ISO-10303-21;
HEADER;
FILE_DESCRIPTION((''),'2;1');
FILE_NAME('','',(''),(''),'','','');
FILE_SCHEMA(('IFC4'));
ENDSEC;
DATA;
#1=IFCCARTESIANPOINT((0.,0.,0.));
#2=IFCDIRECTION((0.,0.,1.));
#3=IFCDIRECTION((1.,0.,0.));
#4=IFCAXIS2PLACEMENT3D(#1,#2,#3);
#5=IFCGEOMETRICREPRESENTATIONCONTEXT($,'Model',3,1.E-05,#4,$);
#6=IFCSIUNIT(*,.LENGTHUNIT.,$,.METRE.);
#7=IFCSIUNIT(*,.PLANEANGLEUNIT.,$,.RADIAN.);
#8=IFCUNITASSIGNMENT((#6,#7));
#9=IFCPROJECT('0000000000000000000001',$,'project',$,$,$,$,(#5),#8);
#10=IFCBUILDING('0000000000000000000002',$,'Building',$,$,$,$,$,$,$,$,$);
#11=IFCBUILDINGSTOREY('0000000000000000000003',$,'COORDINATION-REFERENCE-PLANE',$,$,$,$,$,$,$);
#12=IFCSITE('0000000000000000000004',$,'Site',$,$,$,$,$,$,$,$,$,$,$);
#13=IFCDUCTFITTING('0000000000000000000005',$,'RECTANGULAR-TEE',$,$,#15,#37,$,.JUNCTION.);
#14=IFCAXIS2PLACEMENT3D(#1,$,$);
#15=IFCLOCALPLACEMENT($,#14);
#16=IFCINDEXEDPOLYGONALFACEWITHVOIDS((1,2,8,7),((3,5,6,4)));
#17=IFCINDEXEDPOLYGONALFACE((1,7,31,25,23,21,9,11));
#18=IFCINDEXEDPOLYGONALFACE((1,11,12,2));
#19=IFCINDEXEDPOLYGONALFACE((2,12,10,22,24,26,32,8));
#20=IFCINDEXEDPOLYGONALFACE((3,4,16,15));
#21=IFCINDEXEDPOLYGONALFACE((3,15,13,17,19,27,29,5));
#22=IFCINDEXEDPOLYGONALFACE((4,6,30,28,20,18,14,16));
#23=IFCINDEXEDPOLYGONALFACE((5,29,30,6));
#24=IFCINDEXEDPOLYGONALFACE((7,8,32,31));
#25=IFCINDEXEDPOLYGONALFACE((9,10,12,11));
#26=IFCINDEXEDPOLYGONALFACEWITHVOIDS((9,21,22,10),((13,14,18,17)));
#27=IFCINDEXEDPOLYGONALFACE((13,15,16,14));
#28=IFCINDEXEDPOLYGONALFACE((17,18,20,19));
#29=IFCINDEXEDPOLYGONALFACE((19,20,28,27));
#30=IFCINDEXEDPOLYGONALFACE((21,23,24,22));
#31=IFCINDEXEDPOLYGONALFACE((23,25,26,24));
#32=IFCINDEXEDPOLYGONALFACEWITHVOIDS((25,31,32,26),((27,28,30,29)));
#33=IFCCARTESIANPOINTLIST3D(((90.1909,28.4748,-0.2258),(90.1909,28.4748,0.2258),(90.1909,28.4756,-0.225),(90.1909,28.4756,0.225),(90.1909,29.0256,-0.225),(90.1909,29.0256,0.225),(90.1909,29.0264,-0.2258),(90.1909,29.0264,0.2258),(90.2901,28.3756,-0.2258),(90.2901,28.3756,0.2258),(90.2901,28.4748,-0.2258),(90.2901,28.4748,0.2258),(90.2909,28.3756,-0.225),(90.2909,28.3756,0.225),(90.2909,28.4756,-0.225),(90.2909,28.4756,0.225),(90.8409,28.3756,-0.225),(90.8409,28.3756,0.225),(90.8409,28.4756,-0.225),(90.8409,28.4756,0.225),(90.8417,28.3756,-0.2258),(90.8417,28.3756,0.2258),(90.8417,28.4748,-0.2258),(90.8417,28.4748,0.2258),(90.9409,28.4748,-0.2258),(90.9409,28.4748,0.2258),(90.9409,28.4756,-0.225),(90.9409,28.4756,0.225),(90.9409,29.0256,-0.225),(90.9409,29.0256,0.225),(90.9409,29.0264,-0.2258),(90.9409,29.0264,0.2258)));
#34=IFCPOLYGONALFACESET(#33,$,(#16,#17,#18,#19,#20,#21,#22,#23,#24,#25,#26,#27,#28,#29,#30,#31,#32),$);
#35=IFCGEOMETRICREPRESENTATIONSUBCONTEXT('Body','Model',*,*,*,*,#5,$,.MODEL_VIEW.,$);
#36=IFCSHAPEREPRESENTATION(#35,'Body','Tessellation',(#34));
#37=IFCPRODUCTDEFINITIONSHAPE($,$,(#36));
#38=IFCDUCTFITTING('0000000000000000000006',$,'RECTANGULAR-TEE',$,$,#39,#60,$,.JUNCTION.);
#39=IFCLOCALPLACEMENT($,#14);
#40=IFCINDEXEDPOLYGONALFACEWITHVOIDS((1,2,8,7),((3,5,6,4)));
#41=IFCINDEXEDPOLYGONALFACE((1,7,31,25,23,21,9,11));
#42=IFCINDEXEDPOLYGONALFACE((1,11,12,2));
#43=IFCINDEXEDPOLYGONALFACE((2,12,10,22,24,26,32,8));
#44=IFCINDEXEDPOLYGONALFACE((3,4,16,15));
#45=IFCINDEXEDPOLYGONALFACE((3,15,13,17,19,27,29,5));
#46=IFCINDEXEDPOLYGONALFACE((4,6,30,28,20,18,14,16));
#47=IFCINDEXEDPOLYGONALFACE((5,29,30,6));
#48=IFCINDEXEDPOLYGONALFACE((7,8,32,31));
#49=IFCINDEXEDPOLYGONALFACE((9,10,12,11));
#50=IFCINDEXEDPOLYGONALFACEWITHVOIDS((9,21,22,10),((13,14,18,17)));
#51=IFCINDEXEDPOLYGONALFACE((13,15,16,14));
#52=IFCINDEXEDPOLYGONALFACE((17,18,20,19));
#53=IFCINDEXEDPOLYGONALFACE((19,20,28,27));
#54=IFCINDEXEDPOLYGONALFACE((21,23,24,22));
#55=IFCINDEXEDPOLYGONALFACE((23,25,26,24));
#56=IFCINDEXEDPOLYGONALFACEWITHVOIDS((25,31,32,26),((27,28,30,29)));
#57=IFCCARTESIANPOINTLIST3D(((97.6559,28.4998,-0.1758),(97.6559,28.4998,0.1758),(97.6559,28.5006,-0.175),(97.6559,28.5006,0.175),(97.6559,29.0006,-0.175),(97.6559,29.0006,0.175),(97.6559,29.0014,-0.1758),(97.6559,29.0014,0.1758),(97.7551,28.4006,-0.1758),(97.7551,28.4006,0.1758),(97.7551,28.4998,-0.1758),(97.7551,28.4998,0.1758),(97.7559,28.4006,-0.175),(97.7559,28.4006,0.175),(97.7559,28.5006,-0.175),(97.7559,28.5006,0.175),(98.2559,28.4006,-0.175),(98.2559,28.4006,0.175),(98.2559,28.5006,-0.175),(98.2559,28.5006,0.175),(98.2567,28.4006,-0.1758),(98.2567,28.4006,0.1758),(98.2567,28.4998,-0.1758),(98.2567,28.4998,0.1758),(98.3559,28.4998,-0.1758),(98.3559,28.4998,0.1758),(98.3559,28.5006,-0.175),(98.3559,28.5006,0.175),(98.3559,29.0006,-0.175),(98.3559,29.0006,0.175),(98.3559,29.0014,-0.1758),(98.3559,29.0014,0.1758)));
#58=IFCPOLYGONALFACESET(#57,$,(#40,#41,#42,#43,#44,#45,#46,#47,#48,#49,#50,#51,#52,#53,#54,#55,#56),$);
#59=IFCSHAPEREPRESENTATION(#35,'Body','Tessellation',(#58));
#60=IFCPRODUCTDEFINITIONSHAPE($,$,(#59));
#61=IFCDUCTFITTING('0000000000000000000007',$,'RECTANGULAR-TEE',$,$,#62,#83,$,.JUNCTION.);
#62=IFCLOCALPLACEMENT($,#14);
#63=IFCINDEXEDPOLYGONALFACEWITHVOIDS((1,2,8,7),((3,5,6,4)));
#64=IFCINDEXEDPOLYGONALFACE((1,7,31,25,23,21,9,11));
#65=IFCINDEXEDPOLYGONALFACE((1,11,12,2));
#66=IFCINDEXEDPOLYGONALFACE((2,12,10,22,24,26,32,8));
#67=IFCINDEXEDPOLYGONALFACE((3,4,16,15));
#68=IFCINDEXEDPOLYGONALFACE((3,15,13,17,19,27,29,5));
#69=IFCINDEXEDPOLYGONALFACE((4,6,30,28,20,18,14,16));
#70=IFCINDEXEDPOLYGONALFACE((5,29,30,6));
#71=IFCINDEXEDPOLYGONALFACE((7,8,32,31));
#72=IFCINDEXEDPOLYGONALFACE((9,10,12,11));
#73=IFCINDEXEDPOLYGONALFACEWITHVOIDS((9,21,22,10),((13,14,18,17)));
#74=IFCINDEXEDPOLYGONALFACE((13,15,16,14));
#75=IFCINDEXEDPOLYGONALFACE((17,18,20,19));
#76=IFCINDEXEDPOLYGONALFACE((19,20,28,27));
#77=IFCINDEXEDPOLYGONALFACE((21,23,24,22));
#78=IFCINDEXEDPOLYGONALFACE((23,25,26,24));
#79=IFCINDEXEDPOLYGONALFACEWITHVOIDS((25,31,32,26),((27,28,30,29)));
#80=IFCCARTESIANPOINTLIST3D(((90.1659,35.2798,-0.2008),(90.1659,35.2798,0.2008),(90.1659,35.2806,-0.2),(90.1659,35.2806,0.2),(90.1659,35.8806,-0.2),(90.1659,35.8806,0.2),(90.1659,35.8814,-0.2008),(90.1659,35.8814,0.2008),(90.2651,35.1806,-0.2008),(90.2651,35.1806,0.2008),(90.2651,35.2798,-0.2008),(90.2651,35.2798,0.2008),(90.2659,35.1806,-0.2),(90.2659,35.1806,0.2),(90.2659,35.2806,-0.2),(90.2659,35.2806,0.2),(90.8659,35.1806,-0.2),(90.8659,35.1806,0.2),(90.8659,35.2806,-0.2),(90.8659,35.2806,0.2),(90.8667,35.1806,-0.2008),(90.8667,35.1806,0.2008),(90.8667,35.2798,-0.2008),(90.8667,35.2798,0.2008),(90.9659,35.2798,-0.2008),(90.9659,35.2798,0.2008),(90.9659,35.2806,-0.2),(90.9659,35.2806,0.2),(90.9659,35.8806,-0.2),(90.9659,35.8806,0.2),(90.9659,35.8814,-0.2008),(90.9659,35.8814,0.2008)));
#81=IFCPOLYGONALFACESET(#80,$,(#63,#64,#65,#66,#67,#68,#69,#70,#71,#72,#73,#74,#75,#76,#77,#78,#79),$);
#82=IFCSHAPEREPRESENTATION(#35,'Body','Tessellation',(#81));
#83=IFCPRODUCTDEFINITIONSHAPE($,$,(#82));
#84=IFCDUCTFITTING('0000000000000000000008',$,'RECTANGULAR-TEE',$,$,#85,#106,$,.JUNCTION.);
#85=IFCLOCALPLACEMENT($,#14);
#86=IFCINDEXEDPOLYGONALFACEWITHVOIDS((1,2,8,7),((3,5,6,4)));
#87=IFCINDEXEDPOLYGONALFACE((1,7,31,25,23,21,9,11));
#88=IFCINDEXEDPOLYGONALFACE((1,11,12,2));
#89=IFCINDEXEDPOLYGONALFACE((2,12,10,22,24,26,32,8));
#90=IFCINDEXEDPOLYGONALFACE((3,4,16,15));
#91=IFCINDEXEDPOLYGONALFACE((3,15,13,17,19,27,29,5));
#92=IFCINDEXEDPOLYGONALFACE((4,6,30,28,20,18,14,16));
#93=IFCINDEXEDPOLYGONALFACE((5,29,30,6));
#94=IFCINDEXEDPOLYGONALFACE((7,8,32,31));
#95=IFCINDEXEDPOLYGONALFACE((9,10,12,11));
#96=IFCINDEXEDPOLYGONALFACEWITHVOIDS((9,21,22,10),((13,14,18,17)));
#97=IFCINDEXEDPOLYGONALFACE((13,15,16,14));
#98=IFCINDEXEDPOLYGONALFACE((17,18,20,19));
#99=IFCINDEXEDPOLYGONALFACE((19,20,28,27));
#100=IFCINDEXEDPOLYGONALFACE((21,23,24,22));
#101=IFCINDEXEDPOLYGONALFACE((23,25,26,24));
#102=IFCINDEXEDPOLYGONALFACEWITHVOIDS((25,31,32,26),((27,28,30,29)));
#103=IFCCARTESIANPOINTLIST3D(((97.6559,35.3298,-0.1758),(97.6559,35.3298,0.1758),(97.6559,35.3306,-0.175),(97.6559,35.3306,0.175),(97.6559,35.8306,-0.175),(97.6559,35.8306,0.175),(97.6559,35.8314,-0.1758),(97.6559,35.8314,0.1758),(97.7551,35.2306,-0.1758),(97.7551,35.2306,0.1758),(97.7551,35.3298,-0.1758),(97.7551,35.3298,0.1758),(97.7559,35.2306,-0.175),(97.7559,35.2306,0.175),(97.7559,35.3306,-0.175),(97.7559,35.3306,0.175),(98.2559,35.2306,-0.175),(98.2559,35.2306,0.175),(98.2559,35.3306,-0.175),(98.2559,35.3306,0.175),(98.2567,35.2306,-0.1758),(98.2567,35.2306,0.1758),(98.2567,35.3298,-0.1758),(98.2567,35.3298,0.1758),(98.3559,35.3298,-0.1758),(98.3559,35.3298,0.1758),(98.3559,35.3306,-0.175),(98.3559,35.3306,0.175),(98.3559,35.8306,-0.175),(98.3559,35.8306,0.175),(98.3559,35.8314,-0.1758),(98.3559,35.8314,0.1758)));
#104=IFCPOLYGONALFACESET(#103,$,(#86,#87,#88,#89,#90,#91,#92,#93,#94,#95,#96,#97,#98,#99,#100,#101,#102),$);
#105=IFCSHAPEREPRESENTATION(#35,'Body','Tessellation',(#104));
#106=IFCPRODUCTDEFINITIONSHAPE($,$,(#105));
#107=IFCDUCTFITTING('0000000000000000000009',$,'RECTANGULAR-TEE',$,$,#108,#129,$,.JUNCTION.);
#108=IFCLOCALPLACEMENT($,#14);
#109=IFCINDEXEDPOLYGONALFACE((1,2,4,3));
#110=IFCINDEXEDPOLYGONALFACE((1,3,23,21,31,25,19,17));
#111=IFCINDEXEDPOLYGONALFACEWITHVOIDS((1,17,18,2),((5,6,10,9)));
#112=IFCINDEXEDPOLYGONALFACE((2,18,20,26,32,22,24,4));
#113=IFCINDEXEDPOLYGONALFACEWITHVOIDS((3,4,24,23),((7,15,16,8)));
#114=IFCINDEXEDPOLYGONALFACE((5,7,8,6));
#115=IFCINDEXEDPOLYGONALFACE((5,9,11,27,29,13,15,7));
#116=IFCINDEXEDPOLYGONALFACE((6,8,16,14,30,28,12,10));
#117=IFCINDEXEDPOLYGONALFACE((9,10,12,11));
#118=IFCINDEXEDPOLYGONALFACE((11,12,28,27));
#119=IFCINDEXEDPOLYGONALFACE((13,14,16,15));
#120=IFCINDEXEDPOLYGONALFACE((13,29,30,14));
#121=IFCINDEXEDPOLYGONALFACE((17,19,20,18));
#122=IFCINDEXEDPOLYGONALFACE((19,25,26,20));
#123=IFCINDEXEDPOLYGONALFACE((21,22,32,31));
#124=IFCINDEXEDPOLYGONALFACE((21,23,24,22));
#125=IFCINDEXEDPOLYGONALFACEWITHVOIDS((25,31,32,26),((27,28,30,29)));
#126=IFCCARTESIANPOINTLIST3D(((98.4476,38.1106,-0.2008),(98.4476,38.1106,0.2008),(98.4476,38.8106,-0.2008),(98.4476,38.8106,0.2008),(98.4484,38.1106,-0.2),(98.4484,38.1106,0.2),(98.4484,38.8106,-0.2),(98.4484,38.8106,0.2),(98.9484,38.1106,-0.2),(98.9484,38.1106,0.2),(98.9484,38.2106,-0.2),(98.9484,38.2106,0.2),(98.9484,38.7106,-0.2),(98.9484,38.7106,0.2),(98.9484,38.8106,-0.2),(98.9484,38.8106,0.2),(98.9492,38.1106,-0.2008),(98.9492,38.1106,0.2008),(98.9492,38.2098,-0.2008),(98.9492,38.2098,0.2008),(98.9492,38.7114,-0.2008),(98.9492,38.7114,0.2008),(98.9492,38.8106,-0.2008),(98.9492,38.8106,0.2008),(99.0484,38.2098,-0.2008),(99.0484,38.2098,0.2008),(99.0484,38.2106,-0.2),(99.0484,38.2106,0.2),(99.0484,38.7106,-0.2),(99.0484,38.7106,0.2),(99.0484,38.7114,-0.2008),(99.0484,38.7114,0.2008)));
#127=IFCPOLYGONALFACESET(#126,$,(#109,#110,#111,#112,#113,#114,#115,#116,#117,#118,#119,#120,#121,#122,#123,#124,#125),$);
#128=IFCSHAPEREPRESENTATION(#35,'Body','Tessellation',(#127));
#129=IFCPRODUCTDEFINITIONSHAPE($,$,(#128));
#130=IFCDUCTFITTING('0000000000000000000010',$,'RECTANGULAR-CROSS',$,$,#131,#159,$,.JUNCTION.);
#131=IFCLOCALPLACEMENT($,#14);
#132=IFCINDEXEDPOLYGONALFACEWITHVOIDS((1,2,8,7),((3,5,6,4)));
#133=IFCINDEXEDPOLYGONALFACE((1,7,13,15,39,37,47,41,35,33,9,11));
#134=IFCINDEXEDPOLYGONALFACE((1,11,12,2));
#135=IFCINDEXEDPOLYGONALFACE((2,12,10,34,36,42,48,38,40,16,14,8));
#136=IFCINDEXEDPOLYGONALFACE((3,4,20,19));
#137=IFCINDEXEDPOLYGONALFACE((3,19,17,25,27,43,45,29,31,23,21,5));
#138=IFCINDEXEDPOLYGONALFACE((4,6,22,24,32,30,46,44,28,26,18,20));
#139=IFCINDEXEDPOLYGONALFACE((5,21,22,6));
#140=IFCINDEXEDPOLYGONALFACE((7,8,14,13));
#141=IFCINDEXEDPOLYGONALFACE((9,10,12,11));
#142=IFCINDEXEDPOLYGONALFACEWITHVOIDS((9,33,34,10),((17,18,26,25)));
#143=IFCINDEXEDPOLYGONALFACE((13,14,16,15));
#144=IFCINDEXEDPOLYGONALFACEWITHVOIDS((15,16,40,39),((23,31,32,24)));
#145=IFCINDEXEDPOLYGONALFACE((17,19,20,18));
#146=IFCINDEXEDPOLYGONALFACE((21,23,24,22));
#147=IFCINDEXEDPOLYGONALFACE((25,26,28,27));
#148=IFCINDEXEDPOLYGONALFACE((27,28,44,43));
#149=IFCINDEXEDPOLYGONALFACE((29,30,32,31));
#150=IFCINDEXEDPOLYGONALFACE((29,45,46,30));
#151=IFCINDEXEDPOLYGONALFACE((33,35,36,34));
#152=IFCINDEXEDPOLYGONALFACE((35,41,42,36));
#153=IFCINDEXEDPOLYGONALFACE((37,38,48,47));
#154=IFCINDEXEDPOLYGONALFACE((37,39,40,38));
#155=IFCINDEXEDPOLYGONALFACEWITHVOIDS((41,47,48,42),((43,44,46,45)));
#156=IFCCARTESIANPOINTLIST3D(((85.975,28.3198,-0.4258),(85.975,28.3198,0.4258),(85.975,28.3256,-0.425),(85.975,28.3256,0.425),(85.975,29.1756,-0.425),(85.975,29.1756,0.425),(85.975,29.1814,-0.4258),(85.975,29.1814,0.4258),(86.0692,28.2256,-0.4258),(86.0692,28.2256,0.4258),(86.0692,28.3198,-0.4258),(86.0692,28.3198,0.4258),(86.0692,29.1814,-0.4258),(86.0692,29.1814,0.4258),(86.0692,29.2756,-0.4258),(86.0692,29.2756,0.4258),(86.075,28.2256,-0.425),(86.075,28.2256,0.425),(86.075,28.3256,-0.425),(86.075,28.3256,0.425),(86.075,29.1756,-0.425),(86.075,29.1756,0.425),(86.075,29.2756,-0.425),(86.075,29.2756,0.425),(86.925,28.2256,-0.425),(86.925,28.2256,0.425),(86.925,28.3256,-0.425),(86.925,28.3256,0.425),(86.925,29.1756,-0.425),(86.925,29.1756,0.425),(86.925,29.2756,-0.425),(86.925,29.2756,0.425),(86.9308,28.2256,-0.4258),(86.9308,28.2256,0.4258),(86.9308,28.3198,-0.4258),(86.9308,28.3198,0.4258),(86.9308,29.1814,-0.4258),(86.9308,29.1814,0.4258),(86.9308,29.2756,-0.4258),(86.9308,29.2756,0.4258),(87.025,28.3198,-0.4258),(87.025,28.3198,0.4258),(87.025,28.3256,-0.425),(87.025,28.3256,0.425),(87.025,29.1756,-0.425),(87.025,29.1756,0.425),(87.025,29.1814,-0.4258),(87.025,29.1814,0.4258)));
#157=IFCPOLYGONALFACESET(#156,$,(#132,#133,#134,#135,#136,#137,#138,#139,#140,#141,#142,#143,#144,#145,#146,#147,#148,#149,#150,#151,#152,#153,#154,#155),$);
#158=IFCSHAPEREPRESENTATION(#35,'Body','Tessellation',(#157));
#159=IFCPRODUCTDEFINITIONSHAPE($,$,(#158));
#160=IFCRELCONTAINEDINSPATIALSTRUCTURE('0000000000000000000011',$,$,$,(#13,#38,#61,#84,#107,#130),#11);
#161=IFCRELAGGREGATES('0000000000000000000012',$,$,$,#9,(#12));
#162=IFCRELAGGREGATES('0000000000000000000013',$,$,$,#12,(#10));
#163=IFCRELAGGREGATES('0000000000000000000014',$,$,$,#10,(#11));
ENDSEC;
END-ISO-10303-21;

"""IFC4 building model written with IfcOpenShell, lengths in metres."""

from ifc_helpers import new_model, si_unit, frame, origin_with_axes, place, context, subcontext, project, spatial, rectangle, extrude, boolean, element, save


model = new_model("IFC4")

# Units and contexts
model_context = context("Model", 3, precision=1e-05, world=origin_with_axes())
body_context = subcontext(model_context, "Body", "Model", "MODEL_VIEW")
ifc_project = project(units=[si_unit("LENGTHUNIT", "METRE"), si_unit("PLANEANGLEUNIT", "RADIAN")], contexts=[model_context])

# Site, building, storey
site = spatial("IfcSite", under=ifc_project, Name="Site")
building = spatial("IfcBuilding", under=site, Name="Building")
storey = spatial("IfcBuildingStorey", under=building, Name="COORDINATION-REFERENCE-PLANE")

# Duct fittings
duct_fitting_1_placement = place(None, frame((90.5659, 28.7506, 0.0), z_axis=(1.0, 0.0, 0.0), x_axis=(0.0, -1.0, 0.0)))
solid_1 = boolean("UNION", extrude(rectangle(XDim=0.55, YDim=0.45), frame((0.0, 0.0, -0.375), z_axis=(0.0, 0.0, 1.0), x_axis=(1.0, 0.0, 0.0)), (0.0, 0.0, 1.0), 0.75), extrude(rectangle(XDim=0.55, YDim=0.45), frame((0.0, 0.0, 0.0), z_axis=(1.0, 0.0, 0.0), x_axis=(0.0, 0.0, -1.0)), (0.0, 0.0, 1.0), 0.375))
element("IfcDuctFitting", 1, at=duct_fitting_1_placement, inside=storey, Name="RECTANGULAR-TEE", PredefinedType="JUNCTION", context=body_context, shape_type="CSG", body=[
    boolean("DIFFERENCE", boolean("UNION", extrude(rectangle(XDim=0.5516, YDim=0.4516), frame((0.0, 0.0, -0.375), z_axis=(0.0, 0.0, 1.0), x_axis=(1.0, 0.0, 0.0)), (0.0, 0.0, 1.0), 0.75), extrude(rectangle(XDim=0.5516, YDim=0.4516), frame((0.0, 0.0, 0.0), z_axis=(1.0, 0.0, 0.0), x_axis=(0.0, 0.0, -1.0)), (0.0, 0.0, 1.0), 0.375)), solid_1),
])
duct_fitting_2_placement = place(None, frame((98.0059, 28.7506, 0.0), z_axis=(1.0, 0.0, 0.0), x_axis=(0.0, -1.0, 0.0)))
solid_2 = boolean("UNION", extrude(rectangle(XDim=0.5, YDim=0.35), frame((0.0, 0.0, -0.35), z_axis=(0.0, 0.0, 1.0), x_axis=(1.0, 0.0, 0.0)), (0.0, 0.0, 1.0), 0.7), extrude(rectangle(XDim=0.5, YDim=0.35), frame((0.0, 0.0, 0.0), z_axis=(1.0, 0.0, 0.0), x_axis=(0.0, 0.0, -1.0)), (0.0, 0.0, 1.0), 0.35))
element("IfcDuctFitting", 2, at=duct_fitting_2_placement, inside=storey, Name="RECTANGULAR-TEE", PredefinedType="JUNCTION", context=body_context, shape_type="CSG", body=[
    boolean("DIFFERENCE", boolean("UNION", extrude(rectangle(XDim=0.5016, YDim=0.3516), frame((0.0, 0.0, -0.35), z_axis=(0.0, 0.0, 1.0), x_axis=(1.0, 0.0, 0.0)), (0.0, 0.0, 1.0), 0.7), extrude(rectangle(XDim=0.5016, YDim=0.3516), frame((0.0, 0.0, 0.0), z_axis=(1.0, 0.0, 0.0), x_axis=(0.0, 0.0, -1.0)), (0.0, 0.0, 1.0), 0.35)), solid_2),
])
duct_fitting_3_placement = place(None, frame((90.5659, 35.5806, 0.0), z_axis=(1.0, 0.0, 0.0), x_axis=(0.0, -1.0, 0.0)))
solid_3 = boolean("UNION", extrude(rectangle(XDim=0.6, YDim=0.4), frame((0.0, 0.0, -0.4), z_axis=(0.0, 0.0, 1.0), x_axis=(1.0, 0.0, 0.0)), (0.0, 0.0, 1.0), 0.8), extrude(rectangle(XDim=0.6, YDim=0.4), frame((0.0, 0.0, 0.0), z_axis=(1.0, 0.0, 0.0), x_axis=(0.0, 0.0, -1.0)), (0.0, 0.0, 1.0), 0.4))
element("IfcDuctFitting", 3, at=duct_fitting_3_placement, inside=storey, Name="RECTANGULAR-TEE", PredefinedType="JUNCTION", context=body_context, shape_type="CSG", body=[
    boolean("DIFFERENCE", boolean("UNION", extrude(rectangle(XDim=0.6016, YDim=0.4016), frame((0.0, 0.0, -0.4), z_axis=(0.0, 0.0, 1.0), x_axis=(1.0, 0.0, 0.0)), (0.0, 0.0, 1.0), 0.8), extrude(rectangle(XDim=0.6016, YDim=0.4016), frame((0.0, 0.0, 0.0), z_axis=(1.0, 0.0, 0.0), x_axis=(0.0, 0.0, -1.0)), (0.0, 0.0, 1.0), 0.4)), solid_3),
])
duct_fitting_4_placement = place(None, frame((98.0059, 35.5806, 0.0), z_axis=(1.0, 0.0, 0.0), x_axis=(0.0, -1.0, 0.0)))
solid_4 = boolean("UNION", extrude(rectangle(XDim=0.5, YDim=0.35), frame((0.0, 0.0, -0.35), z_axis=(0.0, 0.0, 1.0), x_axis=(1.0, 0.0, 0.0)), (0.0, 0.0, 1.0), 0.7), extrude(rectangle(XDim=0.5, YDim=0.35), frame((0.0, 0.0, 0.0), z_axis=(1.0, 0.0, 0.0), x_axis=(0.0, 0.0, -1.0)), (0.0, 0.0, 1.0), 0.35))
element("IfcDuctFitting", 4, at=duct_fitting_4_placement, inside=storey, Name="RECTANGULAR-TEE", PredefinedType="JUNCTION", context=body_context, shape_type="CSG", body=[
    boolean("DIFFERENCE", boolean("UNION", extrude(rectangle(XDim=0.5016, YDim=0.3516), frame((0.0, 0.0, -0.35), z_axis=(0.0, 0.0, 1.0), x_axis=(1.0, 0.0, 0.0)), (0.0, 0.0, 1.0), 0.7), extrude(rectangle(XDim=0.5016, YDim=0.3516), frame((0.0, 0.0, 0.0), z_axis=(1.0, 0.0, 0.0), x_axis=(0.0, 0.0, -1.0)), (0.0, 0.0, 1.0), 0.35)), solid_4),
])
duct_fitting_5_placement = place(None, frame((98.6984, 38.4606, 0.0), z_axis=(0.0, 1.0, 0.0), x_axis=(1.0, 0.0, 0.0)))
solid_5 = boolean("UNION", extrude(rectangle(XDim=0.5, YDim=0.4), frame((0.0, 0.0, -0.35), z_axis=(0.0, 0.0, 1.0), x_axis=(1.0, 0.0, 0.0)), (0.0, 0.0, 1.0), 0.7), extrude(rectangle(XDim=0.5, YDim=0.4), frame((0.0, 0.0, 0.0), z_axis=(1.0, 0.0, 0.0), x_axis=(0.0, 0.0, -1.0)), (0.0, 0.0, 1.0), 0.35))
element("IfcDuctFitting", 5, at=duct_fitting_5_placement, inside=storey, Name="RECTANGULAR-TEE", PredefinedType="JUNCTION", context=body_context, shape_type="CSG", body=[
    boolean("DIFFERENCE", boolean("UNION", extrude(rectangle(XDim=0.5016, YDim=0.4016), frame((0.0, 0.0, -0.35), z_axis=(0.0, 0.0, 1.0), x_axis=(1.0, 0.0, 0.0)), (0.0, 0.0, 1.0), 0.7), extrude(rectangle(XDim=0.5016, YDim=0.4016), frame((0.0, 0.0, 0.0), z_axis=(1.0, 0.0, 0.0), x_axis=(0.0, 0.0, -1.0)), (0.0, 0.0, 1.0), 0.35)), solid_5),
])
duct_fitting_6_placement = place(None, frame((86.5, 28.7506, 0.0), z_axis=(0.0, -1.0, 0.0), x_axis=(1.0, 0.0, 0.0)))
solid_6 = boolean("UNION", extrude(rectangle(XDim=0.85, YDim=0.85), frame((0.0, 0.0, -0.525), z_axis=(0.0, 0.0, 1.0), x_axis=(1.0, 0.0, 0.0)), (0.0, 0.0, 1.0), 1.05), extrude(rectangle(XDim=0.85, YDim=0.85), frame((-0.525, 0.0, 0.0), z_axis=(1.0, 0.0, 0.0), x_axis=(0.0, 0.0, -1.0)), (0.0, 0.0, 1.0), 1.05))
element("IfcDuctFitting", 6, at=duct_fitting_6_placement, inside=storey, Name="RECTANGULAR-CROSS", PredefinedType="JUNCTION", context=body_context, shape_type="CSG", body=[
    boolean("DIFFERENCE", boolean("UNION", extrude(rectangle(XDim=0.8616, YDim=0.8516), frame((0.0, 0.0, -0.525), z_axis=(0.0, 0.0, 1.0), x_axis=(1.0, 0.0, 0.0)), (0.0, 0.0, 1.0), 1.05), extrude(rectangle(XDim=0.8616, YDim=0.8516), frame((-0.525, 0.0, 0.0), z_axis=(1.0, 0.0, 0.0), x_axis=(0.0, 0.0, -1.0)), (0.0, 0.0, 1.0), 1.05)), solid_6),
])

save(model, "model.ifc")
